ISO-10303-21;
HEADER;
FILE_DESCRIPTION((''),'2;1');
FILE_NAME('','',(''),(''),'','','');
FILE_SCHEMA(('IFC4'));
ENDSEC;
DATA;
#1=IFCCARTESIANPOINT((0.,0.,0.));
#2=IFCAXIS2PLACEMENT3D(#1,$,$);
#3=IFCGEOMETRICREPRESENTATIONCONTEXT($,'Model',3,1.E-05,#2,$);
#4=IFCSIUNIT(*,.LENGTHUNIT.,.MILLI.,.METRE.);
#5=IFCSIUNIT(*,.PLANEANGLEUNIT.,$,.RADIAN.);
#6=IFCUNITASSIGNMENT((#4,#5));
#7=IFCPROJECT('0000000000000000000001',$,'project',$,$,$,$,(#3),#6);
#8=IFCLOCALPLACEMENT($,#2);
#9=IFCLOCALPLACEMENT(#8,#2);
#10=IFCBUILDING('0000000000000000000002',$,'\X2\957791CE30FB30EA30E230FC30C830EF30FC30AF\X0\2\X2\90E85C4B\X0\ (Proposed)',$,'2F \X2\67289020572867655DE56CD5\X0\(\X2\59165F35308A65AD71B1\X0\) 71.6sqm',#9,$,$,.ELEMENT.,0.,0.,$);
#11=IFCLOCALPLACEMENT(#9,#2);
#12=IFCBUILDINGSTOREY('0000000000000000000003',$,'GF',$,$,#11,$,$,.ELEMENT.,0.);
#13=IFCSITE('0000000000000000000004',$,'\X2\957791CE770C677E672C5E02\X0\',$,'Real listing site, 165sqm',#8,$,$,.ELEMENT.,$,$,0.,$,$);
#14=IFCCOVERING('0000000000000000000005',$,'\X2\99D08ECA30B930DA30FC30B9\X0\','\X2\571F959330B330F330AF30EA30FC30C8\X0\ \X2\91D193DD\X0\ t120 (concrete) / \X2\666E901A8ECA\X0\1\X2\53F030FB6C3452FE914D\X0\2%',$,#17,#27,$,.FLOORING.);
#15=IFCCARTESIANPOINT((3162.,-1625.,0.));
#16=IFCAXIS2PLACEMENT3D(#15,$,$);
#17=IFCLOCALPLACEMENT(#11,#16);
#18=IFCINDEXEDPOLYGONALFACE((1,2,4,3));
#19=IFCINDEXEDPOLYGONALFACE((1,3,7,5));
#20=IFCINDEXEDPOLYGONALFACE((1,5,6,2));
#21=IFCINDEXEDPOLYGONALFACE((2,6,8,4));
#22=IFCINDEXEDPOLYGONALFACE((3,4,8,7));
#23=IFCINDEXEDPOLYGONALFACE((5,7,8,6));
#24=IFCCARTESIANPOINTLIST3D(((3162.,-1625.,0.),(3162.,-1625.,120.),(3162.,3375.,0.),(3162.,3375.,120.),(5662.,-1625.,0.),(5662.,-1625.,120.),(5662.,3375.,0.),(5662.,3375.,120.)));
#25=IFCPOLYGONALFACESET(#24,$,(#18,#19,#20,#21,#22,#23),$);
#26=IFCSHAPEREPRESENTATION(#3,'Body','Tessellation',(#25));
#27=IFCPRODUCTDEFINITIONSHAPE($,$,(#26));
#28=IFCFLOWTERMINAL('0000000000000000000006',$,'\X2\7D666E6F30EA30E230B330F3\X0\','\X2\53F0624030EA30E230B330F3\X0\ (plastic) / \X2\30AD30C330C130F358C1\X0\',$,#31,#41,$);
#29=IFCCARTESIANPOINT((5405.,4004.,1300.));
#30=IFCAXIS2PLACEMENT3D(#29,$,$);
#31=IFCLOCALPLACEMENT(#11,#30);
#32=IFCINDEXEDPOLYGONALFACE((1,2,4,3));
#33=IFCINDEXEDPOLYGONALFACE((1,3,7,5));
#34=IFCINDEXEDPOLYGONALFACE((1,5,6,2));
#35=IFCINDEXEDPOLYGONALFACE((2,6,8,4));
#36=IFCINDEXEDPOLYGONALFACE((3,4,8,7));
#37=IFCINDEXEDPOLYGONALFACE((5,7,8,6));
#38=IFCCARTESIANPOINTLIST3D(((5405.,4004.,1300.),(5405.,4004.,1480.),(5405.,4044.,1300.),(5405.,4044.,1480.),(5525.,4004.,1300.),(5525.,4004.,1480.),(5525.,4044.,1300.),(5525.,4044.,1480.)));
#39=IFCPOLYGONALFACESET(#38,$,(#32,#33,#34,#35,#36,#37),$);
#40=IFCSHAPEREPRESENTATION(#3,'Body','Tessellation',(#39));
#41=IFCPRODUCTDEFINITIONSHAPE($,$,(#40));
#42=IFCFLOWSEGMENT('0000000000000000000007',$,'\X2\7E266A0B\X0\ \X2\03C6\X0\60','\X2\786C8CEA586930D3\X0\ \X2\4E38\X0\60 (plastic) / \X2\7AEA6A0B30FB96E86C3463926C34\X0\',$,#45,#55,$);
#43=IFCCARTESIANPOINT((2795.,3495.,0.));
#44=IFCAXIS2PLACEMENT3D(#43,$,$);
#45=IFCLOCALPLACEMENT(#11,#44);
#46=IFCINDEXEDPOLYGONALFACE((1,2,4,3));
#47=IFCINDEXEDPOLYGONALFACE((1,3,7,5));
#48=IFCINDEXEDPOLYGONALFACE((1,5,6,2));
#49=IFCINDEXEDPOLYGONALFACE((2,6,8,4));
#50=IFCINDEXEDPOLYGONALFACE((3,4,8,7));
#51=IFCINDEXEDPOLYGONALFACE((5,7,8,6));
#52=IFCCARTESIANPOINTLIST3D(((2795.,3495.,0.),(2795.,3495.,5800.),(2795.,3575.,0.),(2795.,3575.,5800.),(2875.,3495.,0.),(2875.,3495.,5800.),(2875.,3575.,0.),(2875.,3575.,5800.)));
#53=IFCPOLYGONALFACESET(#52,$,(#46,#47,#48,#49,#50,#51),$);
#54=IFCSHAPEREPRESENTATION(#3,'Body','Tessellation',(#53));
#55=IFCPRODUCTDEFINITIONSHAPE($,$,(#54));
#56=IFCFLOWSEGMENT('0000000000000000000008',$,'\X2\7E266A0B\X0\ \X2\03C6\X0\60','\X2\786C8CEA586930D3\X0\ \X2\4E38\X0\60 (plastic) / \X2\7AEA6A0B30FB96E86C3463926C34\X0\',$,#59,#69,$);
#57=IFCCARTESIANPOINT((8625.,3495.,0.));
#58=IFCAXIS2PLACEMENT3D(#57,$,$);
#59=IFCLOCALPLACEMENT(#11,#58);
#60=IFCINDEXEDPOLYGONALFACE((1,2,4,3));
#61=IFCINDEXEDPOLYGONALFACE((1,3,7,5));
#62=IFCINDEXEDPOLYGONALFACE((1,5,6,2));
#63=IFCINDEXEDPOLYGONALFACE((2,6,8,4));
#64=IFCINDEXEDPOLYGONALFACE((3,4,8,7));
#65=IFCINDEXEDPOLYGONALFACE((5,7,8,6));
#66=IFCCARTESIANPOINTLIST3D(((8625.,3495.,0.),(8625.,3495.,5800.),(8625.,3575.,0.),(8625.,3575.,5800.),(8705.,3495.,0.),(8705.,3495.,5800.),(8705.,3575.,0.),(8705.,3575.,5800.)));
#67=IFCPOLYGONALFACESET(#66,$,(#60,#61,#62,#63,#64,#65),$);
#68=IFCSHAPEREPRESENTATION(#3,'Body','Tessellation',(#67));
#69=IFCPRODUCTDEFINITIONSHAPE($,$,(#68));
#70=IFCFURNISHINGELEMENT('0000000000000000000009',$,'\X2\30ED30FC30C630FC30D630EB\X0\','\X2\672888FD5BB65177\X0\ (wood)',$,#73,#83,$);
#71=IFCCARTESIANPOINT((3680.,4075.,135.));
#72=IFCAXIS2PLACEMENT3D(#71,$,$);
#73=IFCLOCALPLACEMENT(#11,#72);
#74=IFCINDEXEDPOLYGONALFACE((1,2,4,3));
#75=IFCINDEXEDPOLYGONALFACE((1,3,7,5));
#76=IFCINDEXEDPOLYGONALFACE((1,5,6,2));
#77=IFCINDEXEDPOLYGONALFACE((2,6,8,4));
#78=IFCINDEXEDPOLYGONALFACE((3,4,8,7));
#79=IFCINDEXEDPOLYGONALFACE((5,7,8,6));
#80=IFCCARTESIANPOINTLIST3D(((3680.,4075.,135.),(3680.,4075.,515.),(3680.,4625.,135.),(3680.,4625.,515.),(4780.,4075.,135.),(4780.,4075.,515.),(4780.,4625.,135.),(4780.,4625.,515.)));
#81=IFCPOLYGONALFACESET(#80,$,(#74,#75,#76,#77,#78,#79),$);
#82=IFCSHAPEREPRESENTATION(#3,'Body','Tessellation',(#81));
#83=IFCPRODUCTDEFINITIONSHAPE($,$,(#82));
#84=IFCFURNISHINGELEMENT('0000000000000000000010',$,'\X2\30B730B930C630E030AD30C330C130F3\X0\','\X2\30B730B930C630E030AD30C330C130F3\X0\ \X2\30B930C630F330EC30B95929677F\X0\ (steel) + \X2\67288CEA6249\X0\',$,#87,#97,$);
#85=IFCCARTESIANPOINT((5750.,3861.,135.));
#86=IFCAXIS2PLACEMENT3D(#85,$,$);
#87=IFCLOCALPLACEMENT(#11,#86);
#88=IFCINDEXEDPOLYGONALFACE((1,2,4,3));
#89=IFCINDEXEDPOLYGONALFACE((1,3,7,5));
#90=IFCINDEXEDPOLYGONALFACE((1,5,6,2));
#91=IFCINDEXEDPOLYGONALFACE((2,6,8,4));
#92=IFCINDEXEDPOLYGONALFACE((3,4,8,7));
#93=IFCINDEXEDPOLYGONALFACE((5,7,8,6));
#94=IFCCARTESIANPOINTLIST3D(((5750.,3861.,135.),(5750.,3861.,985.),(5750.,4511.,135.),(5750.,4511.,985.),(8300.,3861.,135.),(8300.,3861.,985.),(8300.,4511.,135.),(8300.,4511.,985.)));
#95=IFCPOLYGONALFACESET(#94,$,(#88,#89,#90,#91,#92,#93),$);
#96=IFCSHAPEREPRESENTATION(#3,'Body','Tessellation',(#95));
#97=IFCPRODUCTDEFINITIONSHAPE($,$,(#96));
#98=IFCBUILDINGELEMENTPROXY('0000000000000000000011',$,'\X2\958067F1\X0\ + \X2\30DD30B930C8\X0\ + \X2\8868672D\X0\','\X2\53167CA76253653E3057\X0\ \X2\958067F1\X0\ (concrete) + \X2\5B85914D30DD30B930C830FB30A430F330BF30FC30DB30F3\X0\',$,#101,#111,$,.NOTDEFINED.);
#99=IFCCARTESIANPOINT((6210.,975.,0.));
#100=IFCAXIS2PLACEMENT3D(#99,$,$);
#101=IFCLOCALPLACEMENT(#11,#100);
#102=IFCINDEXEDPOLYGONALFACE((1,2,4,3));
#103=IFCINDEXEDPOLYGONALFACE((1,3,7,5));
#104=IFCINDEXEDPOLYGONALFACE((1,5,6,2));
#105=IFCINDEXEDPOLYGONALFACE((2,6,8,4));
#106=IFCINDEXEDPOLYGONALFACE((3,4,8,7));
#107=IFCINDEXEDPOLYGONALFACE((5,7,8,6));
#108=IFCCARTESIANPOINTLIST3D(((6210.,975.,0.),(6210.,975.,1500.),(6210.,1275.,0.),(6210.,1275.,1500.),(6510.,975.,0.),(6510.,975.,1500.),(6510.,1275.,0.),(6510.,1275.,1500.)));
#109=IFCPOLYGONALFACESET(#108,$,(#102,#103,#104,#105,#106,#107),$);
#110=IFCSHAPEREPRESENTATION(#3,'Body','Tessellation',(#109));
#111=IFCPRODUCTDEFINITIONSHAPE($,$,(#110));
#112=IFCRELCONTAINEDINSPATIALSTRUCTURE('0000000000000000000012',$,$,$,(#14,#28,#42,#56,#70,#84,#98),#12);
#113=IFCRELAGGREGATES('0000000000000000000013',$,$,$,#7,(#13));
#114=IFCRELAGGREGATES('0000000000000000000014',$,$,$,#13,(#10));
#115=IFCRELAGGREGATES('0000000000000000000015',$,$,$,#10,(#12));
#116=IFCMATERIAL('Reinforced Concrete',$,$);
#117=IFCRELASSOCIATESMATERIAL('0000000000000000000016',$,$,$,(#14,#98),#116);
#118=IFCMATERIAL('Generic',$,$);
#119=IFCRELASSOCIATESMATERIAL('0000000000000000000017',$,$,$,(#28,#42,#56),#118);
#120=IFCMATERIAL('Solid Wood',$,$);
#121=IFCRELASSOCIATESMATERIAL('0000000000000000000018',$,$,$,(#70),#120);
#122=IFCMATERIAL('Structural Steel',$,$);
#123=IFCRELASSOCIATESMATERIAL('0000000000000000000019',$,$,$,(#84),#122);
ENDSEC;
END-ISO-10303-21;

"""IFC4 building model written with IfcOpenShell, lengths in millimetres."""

from ifc_helpers import new_model, si_unit, frame, frame_2d, origin, place, context, project, spatial, rectangle, extrude, material, element, save


model = new_model("IFC4")

# Units and contexts
model_context = context("Model", 3, precision=1e-05, world=origin())
ifc_project = project(units=[si_unit("LENGTHUNIT", "METRE", prefix="MILLI"), si_unit("PLANEANGLEUNIT", "RADIAN")], contexts=[model_context])

# Site, building, storey
site_placement = place(None, origin())
site = spatial("IfcSite", under=ifc_project, at=site_placement, Name="長野県松本市", ObjectType="Real listing site, 165sqm", CompositionType="ELEMENT", RefElevation=0.0)
building_placement = place(site_placement, origin())
building = spatial("IfcBuilding", under=site, at=building_placement, Name="長野・リモートワーク2部屋 (Proposed)", ObjectType="2F 木造在来工法(外張り断熱) 71.6sqm", CompositionType="ELEMENT", ElevationOfRefHeight=0.0, ElevationOfTerrain=0.0)
storey_placement = place(building_placement, origin())
storey = spatial("IfcBuildingStorey", under=building, at=storey_placement, Name="GF", CompositionType="ELEMENT", Elevation=0.0)

# Shared definitions
ifc_material_1 = material(Name="Solid Wood")

# Shared definitions
ifc_material_2 = material(Name="Reinforced Concrete")

# Covering
ifc_material_3 = material(Name="Generic")
covering_1_placement = place(storey_placement, frame((3162.0, -1625.0, 0.0)))
element("IfcCovering", 1, at=covering_1_placement, inside=storey, material=ifc_material_2, Name="駐車スペース", Description="土間コンクリート 金鏝 t120 (concrete) / 普通車1台・水勾配2%", PredefinedType="FLOORING", context=model_context, shape_type="SweptSolid", body=[
    extrude(rectangle(XDim=2500.0, YDim=5000.0, at=frame_2d((1250.0, 2500.0))), frame((3162.0, -1625.0, 0.0)), (0.0, 0.0, 1.0), 120.0),
])

# Flow terminal
flow_terminal_placement = place(storey_placement, frame((5405.0, 4004.0, 1300.0)))
element("IfcFlowTerminal", 2, at=flow_terminal_placement, inside=storey, material=ifc_material_3, Name="給湯リモコン", Description="台所リモコン (plastic) / キッチン壁", context=model_context, shape_type="SweptSolid", body=[
    extrude(rectangle(XDim=120.0, YDim=40.0, at=frame_2d((60.0, 20.0))), frame((5405.0, 4004.0, 1300.0)), (0.0, 0.0, 1.0), 180.0),
])

# Flow segments
flow_segment_1_placement = place(storey_placement, frame((2795.0, 3495.0, 0.0)))
element("IfcFlowSegment", 3, at=flow_segment_1_placement, inside=storey, material=ifc_material_3, Name="縦樋 φ60", Description="硬質塩ビ 丸60 (plastic) / 竪樋・雨水排水", context=model_context, shape_type="SweptSolid", body=[
    extrude(rectangle(XDim=80.0, YDim=80.0, at=frame_2d((40.0, 40.0))), frame((2795.0, 3495.0, 0.0)), (0.0, 0.0, 1.0), 5800.0),
])
flow_segment_2_placement = place(storey_placement, frame((8625.0, 3495.0, 0.0)))
element("IfcFlowSegment", 4, at=flow_segment_2_placement, inside=storey, material=ifc_material_3, Name="縦樋 φ60", Description="硬質塩ビ 丸60 (plastic) / 竪樋・雨水排水", context=model_context, shape_type="SweptSolid", body=[
    extrude(rectangle(XDim=80.0, YDim=80.0, at=frame_2d((40.0, 40.0))), frame((8625.0, 3495.0, 0.0)), (0.0, 0.0, 1.0), 5800.0),
])

# Furnishing elements
furnishing_1_placement = place(storey_placement, frame((3680.0, 4075.0, 135.0)))
element("IfcFurnishingElement", 5, at=furnishing_1_placement, inside=storey, material=ifc_material_1, Name="ローテーブル", Description="木製家具 (wood)", context=model_context, shape_type="SweptSolid", body=[
    extrude(rectangle(XDim=1100.0, YDim=550.0, at=frame_2d((550.0, 275.0))), frame((3680.0, 4075.0, 135.0)), (0.0, 0.0, 1.0), 380.0),
])
ifc_material_4 = material(Name="Structural Steel")
furnishing_2_placement = place(storey_placement, frame((5750.0, 3861.0, 135.0)))
element("IfcFurnishingElement", 6, at=furnishing_2_placement, inside=storey, material=ifc_material_4, Name="システムキッチン", Description="システムキッチン ステンレス天板 (steel) + 木質扉", context=model_context, shape_type="SweptSolid", body=[
    extrude(rectangle(XDim=2550.0, YDim=650.0, at=frame_2d((1275.0, 325.0))), frame((5750.0, 3861.0, 135.0)), (0.0, 0.0, 1.0), 850.0),
])

# Building element proxy
proxy_placement = place(storey_placement, frame((6210.0, 975.0, 0.0)))
element("IfcBuildingElementProxy", 7, at=proxy_placement, inside=storey, material=ifc_material_2, Name="門柱 + ポスト + 表札", Description="化粧打放し 門柱 (concrete) + 宅配ポスト・インターホン", PredefinedType="NOTDEFINED", context=model_context, shape_type="SweptSolid", body=[
    extrude(rectangle(XDim=300.0, YDim=300.0, at=frame_2d((150.0, 150.0))), frame((6210.0, 975.0, 0.0)), (0.0, 0.0, 1.0), 1500.0),
])

save(model, "model.ifc")
